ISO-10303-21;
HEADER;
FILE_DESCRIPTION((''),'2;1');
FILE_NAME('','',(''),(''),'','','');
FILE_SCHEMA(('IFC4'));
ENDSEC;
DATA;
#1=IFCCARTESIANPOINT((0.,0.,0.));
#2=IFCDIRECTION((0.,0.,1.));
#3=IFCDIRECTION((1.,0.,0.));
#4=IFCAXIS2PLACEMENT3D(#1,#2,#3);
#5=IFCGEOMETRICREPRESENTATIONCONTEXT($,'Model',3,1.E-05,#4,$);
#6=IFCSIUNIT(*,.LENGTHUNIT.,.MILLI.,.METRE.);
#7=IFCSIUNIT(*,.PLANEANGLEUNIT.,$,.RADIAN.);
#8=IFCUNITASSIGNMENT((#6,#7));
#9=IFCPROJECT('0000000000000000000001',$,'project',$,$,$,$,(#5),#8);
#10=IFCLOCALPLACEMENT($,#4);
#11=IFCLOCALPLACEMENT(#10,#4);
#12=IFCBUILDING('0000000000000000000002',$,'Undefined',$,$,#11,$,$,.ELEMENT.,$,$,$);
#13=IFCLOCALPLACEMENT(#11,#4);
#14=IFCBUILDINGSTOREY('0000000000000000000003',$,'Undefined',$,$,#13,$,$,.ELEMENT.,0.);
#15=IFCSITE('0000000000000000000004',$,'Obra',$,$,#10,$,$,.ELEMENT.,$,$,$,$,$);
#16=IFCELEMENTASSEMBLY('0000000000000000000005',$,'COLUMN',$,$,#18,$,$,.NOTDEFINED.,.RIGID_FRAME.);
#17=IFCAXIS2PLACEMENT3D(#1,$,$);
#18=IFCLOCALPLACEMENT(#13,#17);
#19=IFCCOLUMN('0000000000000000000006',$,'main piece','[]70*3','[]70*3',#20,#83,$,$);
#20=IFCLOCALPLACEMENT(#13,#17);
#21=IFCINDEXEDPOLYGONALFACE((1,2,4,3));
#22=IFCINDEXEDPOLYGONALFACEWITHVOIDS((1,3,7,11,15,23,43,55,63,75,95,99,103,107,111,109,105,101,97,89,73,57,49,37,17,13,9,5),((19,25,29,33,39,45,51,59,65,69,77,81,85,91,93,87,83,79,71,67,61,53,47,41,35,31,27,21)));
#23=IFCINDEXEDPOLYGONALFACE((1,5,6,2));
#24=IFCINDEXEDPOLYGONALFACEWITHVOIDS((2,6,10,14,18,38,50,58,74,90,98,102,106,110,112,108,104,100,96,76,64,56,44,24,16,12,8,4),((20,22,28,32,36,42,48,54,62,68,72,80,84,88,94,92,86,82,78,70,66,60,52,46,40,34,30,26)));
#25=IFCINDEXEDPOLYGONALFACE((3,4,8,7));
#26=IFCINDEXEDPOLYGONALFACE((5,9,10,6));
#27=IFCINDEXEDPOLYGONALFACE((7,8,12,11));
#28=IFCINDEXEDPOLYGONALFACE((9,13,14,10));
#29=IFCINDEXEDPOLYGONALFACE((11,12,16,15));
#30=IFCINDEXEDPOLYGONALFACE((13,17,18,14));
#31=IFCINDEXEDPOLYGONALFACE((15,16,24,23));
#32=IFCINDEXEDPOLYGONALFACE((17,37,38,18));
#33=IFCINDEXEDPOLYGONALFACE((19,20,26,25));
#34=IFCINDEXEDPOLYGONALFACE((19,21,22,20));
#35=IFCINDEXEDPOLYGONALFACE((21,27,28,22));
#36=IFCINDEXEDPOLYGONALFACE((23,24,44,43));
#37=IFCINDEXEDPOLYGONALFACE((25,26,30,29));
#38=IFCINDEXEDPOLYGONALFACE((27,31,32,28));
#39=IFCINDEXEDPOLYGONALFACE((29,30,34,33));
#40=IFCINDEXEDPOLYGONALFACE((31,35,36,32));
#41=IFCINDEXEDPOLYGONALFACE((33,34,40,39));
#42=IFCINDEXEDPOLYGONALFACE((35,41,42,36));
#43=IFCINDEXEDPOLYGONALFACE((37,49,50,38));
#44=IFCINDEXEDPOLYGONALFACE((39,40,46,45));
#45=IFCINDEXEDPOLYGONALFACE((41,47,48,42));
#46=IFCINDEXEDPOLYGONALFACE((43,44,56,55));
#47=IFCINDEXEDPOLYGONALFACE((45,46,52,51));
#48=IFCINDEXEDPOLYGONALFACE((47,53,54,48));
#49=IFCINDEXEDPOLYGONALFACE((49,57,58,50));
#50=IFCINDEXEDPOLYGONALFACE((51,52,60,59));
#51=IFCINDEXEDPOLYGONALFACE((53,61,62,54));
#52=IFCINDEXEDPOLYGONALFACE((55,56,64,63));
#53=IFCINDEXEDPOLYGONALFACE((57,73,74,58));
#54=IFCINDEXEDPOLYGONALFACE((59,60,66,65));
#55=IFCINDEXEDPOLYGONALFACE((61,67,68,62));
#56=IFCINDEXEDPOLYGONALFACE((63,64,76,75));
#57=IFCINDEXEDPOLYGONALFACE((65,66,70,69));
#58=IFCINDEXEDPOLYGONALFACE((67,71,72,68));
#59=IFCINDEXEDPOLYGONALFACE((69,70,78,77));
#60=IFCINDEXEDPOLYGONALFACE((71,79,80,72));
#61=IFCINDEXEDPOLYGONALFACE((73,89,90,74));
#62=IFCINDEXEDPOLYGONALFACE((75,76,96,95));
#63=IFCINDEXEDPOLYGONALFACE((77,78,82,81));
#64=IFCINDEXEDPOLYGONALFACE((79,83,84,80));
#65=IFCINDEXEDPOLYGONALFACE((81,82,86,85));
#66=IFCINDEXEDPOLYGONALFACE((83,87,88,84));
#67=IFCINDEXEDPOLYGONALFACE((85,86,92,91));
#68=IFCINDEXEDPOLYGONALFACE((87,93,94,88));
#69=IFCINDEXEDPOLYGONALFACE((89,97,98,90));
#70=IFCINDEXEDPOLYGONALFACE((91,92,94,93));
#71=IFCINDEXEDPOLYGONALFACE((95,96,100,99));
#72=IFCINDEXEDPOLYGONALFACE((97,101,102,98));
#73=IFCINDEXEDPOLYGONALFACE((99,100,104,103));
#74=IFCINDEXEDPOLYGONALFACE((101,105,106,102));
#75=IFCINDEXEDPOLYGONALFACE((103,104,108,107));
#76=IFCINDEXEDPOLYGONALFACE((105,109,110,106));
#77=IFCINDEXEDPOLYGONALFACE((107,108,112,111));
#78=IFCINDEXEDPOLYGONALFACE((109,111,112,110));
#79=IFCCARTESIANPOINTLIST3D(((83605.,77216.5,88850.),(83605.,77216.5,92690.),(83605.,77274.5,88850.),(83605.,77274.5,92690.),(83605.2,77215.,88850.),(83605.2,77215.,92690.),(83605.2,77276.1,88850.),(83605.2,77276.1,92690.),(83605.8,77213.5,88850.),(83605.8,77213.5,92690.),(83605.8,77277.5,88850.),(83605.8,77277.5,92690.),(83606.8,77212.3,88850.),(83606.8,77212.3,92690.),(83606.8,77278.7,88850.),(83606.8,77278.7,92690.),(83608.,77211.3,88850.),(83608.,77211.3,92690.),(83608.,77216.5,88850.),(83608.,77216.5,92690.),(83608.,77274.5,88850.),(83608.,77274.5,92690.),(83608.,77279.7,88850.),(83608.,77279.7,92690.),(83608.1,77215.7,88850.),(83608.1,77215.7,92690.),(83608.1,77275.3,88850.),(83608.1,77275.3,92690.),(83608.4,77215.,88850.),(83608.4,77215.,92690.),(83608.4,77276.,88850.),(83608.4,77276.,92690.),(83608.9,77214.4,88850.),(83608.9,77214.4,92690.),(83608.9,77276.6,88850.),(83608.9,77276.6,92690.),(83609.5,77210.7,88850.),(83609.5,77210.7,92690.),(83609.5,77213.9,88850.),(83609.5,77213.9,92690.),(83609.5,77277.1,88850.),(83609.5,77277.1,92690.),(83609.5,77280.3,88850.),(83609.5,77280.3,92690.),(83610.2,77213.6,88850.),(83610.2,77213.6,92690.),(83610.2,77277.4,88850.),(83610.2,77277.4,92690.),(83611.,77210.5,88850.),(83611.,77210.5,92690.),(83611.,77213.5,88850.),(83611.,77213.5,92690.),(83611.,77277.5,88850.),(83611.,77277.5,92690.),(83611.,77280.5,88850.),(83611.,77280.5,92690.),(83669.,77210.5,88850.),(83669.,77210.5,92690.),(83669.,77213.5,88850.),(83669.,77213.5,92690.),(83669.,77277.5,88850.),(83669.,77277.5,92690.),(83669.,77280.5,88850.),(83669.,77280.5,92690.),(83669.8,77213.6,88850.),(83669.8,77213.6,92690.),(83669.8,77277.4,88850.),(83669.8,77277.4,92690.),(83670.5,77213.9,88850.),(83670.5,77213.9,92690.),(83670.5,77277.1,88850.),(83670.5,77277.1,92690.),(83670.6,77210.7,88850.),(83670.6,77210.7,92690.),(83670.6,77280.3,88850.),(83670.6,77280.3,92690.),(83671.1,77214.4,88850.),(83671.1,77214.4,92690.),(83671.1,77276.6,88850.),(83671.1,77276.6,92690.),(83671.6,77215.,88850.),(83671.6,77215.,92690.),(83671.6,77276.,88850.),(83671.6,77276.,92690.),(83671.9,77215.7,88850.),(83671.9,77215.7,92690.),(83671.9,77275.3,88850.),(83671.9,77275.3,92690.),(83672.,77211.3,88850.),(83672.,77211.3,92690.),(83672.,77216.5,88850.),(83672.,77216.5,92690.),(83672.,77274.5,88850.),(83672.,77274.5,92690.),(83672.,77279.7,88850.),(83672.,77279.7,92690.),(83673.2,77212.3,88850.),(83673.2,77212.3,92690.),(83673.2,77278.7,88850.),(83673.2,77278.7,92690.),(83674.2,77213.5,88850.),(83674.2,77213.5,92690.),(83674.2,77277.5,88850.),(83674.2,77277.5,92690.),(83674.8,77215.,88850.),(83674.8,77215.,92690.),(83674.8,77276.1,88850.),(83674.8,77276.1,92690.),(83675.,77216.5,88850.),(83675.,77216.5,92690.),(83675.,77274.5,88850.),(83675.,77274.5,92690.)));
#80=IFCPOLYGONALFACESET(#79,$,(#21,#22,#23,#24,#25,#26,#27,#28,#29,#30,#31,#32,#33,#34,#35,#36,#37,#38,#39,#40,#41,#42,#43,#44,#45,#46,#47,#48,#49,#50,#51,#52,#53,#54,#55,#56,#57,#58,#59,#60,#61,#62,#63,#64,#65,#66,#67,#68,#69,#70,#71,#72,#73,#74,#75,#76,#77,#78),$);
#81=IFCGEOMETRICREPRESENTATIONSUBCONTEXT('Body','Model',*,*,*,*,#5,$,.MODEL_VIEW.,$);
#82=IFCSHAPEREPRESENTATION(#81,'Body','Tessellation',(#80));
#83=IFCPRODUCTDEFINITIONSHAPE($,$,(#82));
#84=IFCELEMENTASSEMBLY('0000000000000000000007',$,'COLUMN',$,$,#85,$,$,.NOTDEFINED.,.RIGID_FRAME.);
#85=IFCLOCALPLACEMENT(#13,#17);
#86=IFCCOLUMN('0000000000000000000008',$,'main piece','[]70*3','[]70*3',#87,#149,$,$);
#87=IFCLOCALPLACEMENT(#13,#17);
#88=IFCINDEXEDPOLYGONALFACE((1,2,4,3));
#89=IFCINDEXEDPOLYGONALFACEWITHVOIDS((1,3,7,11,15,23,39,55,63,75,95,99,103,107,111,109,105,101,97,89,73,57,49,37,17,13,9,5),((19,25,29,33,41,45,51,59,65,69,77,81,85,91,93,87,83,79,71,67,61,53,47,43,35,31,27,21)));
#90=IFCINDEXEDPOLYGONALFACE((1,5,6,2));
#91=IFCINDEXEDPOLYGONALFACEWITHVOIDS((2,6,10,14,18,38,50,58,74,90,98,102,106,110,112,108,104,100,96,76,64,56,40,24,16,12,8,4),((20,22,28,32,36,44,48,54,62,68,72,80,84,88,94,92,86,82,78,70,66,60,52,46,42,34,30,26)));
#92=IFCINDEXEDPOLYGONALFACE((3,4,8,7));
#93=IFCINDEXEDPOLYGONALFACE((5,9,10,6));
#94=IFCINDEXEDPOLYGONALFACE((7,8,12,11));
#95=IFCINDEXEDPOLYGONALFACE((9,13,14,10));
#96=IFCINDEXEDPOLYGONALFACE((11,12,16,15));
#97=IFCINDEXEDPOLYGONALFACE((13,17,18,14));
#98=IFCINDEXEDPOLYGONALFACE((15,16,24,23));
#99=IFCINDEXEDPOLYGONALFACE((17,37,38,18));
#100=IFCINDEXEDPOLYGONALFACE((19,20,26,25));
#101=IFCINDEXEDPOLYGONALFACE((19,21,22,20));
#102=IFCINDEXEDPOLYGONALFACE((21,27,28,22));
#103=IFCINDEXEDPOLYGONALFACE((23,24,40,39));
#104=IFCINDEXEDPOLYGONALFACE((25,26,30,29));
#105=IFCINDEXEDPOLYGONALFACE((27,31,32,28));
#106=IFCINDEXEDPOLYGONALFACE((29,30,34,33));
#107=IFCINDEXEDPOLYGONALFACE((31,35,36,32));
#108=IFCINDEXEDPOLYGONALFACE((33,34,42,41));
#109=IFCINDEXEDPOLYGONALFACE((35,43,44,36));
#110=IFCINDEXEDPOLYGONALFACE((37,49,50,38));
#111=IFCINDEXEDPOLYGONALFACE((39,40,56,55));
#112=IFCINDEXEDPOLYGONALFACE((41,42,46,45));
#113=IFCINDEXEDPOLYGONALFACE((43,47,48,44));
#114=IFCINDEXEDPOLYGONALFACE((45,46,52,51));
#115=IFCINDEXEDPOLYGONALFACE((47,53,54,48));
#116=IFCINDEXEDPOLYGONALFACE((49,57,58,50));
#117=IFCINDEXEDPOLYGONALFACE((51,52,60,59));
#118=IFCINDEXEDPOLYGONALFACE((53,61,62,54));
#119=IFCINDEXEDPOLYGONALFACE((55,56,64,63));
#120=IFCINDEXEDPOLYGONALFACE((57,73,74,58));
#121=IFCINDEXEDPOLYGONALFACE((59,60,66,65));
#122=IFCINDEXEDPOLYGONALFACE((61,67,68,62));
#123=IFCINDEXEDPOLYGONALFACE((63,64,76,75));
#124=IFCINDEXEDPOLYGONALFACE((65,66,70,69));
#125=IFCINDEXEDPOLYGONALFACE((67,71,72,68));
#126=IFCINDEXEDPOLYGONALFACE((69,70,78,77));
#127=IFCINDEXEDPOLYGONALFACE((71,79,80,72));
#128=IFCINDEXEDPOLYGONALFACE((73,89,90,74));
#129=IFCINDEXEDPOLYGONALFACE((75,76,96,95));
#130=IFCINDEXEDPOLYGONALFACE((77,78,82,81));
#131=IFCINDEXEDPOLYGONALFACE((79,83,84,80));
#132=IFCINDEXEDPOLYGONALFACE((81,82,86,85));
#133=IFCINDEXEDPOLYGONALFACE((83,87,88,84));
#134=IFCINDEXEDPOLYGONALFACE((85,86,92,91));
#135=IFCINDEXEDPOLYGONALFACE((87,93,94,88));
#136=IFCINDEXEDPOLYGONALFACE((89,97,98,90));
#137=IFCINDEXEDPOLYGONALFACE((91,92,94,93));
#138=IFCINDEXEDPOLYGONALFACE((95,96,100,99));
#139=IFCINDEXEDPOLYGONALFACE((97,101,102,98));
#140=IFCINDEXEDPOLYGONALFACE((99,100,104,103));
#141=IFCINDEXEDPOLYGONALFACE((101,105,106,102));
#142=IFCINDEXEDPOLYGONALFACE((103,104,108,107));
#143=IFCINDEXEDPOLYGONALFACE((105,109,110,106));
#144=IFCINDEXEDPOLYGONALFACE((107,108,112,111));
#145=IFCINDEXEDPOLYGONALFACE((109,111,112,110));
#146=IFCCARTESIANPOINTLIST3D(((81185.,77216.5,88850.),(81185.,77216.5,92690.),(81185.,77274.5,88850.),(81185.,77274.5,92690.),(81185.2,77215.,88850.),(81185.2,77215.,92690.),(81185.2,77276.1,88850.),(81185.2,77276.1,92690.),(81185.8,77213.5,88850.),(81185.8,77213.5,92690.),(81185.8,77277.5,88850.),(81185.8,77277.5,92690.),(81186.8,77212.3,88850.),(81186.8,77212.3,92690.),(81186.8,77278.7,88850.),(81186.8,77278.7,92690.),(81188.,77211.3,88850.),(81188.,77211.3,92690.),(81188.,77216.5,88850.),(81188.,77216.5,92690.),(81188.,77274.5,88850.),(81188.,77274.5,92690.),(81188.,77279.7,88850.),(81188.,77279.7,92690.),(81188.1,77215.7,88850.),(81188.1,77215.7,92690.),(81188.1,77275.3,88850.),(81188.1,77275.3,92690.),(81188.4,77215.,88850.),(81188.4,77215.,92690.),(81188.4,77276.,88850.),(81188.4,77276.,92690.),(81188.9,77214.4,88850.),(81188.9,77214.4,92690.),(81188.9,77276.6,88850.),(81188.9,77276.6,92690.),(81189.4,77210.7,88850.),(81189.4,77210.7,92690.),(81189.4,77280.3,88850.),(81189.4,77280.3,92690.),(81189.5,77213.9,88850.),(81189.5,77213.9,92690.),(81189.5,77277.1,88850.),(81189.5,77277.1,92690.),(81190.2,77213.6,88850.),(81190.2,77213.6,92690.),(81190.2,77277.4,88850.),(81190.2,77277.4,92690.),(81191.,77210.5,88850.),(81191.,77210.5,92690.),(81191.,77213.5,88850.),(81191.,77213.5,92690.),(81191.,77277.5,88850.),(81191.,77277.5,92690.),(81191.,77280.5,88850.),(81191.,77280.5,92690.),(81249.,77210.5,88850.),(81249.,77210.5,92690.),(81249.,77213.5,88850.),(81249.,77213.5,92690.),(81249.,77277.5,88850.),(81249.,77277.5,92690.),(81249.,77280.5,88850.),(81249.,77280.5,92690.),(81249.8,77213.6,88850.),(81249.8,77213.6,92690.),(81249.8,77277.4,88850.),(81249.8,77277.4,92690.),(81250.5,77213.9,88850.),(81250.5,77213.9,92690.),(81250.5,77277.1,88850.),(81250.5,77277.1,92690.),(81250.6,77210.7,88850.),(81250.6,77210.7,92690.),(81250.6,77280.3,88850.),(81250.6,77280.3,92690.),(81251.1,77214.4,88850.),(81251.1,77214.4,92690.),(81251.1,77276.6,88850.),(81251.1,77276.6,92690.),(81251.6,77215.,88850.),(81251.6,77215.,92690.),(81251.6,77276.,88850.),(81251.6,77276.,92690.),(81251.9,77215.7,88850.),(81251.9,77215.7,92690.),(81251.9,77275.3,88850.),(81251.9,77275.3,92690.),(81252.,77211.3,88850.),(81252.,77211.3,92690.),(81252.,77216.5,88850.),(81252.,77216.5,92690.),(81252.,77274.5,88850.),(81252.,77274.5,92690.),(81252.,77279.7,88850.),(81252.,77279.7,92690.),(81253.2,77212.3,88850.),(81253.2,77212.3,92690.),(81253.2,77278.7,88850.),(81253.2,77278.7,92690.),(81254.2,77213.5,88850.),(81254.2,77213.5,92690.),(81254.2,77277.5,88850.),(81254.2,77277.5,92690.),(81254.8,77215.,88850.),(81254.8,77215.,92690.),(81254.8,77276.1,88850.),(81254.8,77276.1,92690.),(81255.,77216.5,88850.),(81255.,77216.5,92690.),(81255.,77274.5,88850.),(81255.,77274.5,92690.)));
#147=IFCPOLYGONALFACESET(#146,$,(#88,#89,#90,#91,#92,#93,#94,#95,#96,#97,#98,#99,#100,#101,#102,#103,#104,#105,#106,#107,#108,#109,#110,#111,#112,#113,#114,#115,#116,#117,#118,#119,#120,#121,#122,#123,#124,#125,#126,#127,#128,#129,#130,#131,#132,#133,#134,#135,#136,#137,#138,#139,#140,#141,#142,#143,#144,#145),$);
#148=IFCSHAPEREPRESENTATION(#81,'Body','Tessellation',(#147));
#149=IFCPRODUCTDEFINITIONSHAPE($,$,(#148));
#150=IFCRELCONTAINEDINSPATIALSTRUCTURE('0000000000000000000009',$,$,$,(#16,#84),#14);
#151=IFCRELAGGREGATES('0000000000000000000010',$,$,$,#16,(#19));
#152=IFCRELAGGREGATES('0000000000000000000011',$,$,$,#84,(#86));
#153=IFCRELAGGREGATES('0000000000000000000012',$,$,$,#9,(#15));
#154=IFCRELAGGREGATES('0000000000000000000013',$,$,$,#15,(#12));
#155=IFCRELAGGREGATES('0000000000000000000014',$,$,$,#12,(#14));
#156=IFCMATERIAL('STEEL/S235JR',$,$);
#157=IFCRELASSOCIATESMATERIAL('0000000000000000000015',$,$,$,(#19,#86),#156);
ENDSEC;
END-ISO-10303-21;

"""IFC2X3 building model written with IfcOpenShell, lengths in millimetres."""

from ifc_helpers import new_model, si_unit, frame, origin_with_axes, origin_2d_with_axis, place, context, subcontext, project, spatial, hollow_rectangle, extrude, material, element, aggregate, save


model = new_model("IFC2X3")

# Units and contexts
model_context = context("Model", 3, precision=1e-05, world=origin_with_axes())
body_context = subcontext(model_context, "Body", "Model", "MODEL_VIEW")
ifc_project = project(units=[si_unit("LENGTHUNIT", "METRE", prefix="MILLI"), si_unit("PLANEANGLEUNIT", "RADIAN")], contexts=[model_context])

# Site, building, storey
site_placement = place(None, origin_with_axes())
site = spatial("IfcSite", under=ifc_project, at=site_placement, Name="Obra", CompositionType="ELEMENT")
building_placement = place(site_placement, origin_with_axes())
building = spatial("IfcBuilding", under=site, at=building_placement, Name="Undefined", CompositionType="ELEMENT")
storey_placement = place(building_placement, origin_with_axes())
storey = spatial("IfcBuildingStorey", under=building, at=storey_placement, Name="Undefined", CompositionType="ELEMENT", Elevation=0.0)

# Element assemblies, columns
ifc_material = material(Name="STEEL/S235JR")
assembly_1_placement = place(storey_placement, origin_with_axes())
assembly_1 = element("IfcElementAssembly", 1, at=assembly_1_placement, inside=storey, Name="COLUMN", AssemblyPlace="NOTDEFINED", PredefinedType="RIGID_FRAME")
column_1_placement = place(assembly_1_placement, frame((83640.0, 77245.5, 88850.0), z_axis=(0.0, 0.0, 1.0), x_axis=(0.0, 1.0, 0.0)))
column_1 = element("IfcColumn", 2, at=column_1_placement, material=ifc_material, Name="main piece", Description="[]70*3", ObjectType="[]70*3", context=body_context, shape_type="SweptSolid", body=[
    extrude(hollow_rectangle(XDim=70.0, YDim=70.0, WallThickness=3.0, InnerFilletRadius=3.0, OuterFilletRadius=6.0, at=origin_2d_with_axis()), frame((0.0, 0.0, 3840.0), z_axis=(0.0, 0.0, -1.0), x_axis=(0.0, 1.0, 0.0)), (0.0, 0.0, 1.0), 3840.0),
])
aggregate(assembly_1, [column_1])
assembly_2_placement = place(storey_placement, origin_with_axes())
assembly_2 = element("IfcElementAssembly", 3, at=assembly_2_placement, inside=storey, Name="COLUMN", AssemblyPlace="NOTDEFINED", PredefinedType="RIGID_FRAME")
column_2_placement = place(assembly_2_placement, frame((81220.0, 77245.5, 88850.0), z_axis=(0.0, 0.0, 1.0), x_axis=(0.0, 1.0, 0.0)))
column_2 = element("IfcColumn", 4, at=column_2_placement, material=ifc_material, Name="main piece", Description="[]70*3", ObjectType="[]70*3", context=body_context, shape_type="SweptSolid", body=[
    extrude(hollow_rectangle(XDim=70.0, YDim=70.0, WallThickness=3.0, InnerFilletRadius=3.0, OuterFilletRadius=6.0, at=origin_2d_with_axis()), frame((0.0, 0.0, 3840.0), z_axis=(0.0, 0.0, -1.0), x_axis=(0.0, 1.0, 0.0)), (0.0, 0.0, 1.0), 3840.0),
])
aggregate(assembly_2, [column_2])

save(model, "model.ifc")
